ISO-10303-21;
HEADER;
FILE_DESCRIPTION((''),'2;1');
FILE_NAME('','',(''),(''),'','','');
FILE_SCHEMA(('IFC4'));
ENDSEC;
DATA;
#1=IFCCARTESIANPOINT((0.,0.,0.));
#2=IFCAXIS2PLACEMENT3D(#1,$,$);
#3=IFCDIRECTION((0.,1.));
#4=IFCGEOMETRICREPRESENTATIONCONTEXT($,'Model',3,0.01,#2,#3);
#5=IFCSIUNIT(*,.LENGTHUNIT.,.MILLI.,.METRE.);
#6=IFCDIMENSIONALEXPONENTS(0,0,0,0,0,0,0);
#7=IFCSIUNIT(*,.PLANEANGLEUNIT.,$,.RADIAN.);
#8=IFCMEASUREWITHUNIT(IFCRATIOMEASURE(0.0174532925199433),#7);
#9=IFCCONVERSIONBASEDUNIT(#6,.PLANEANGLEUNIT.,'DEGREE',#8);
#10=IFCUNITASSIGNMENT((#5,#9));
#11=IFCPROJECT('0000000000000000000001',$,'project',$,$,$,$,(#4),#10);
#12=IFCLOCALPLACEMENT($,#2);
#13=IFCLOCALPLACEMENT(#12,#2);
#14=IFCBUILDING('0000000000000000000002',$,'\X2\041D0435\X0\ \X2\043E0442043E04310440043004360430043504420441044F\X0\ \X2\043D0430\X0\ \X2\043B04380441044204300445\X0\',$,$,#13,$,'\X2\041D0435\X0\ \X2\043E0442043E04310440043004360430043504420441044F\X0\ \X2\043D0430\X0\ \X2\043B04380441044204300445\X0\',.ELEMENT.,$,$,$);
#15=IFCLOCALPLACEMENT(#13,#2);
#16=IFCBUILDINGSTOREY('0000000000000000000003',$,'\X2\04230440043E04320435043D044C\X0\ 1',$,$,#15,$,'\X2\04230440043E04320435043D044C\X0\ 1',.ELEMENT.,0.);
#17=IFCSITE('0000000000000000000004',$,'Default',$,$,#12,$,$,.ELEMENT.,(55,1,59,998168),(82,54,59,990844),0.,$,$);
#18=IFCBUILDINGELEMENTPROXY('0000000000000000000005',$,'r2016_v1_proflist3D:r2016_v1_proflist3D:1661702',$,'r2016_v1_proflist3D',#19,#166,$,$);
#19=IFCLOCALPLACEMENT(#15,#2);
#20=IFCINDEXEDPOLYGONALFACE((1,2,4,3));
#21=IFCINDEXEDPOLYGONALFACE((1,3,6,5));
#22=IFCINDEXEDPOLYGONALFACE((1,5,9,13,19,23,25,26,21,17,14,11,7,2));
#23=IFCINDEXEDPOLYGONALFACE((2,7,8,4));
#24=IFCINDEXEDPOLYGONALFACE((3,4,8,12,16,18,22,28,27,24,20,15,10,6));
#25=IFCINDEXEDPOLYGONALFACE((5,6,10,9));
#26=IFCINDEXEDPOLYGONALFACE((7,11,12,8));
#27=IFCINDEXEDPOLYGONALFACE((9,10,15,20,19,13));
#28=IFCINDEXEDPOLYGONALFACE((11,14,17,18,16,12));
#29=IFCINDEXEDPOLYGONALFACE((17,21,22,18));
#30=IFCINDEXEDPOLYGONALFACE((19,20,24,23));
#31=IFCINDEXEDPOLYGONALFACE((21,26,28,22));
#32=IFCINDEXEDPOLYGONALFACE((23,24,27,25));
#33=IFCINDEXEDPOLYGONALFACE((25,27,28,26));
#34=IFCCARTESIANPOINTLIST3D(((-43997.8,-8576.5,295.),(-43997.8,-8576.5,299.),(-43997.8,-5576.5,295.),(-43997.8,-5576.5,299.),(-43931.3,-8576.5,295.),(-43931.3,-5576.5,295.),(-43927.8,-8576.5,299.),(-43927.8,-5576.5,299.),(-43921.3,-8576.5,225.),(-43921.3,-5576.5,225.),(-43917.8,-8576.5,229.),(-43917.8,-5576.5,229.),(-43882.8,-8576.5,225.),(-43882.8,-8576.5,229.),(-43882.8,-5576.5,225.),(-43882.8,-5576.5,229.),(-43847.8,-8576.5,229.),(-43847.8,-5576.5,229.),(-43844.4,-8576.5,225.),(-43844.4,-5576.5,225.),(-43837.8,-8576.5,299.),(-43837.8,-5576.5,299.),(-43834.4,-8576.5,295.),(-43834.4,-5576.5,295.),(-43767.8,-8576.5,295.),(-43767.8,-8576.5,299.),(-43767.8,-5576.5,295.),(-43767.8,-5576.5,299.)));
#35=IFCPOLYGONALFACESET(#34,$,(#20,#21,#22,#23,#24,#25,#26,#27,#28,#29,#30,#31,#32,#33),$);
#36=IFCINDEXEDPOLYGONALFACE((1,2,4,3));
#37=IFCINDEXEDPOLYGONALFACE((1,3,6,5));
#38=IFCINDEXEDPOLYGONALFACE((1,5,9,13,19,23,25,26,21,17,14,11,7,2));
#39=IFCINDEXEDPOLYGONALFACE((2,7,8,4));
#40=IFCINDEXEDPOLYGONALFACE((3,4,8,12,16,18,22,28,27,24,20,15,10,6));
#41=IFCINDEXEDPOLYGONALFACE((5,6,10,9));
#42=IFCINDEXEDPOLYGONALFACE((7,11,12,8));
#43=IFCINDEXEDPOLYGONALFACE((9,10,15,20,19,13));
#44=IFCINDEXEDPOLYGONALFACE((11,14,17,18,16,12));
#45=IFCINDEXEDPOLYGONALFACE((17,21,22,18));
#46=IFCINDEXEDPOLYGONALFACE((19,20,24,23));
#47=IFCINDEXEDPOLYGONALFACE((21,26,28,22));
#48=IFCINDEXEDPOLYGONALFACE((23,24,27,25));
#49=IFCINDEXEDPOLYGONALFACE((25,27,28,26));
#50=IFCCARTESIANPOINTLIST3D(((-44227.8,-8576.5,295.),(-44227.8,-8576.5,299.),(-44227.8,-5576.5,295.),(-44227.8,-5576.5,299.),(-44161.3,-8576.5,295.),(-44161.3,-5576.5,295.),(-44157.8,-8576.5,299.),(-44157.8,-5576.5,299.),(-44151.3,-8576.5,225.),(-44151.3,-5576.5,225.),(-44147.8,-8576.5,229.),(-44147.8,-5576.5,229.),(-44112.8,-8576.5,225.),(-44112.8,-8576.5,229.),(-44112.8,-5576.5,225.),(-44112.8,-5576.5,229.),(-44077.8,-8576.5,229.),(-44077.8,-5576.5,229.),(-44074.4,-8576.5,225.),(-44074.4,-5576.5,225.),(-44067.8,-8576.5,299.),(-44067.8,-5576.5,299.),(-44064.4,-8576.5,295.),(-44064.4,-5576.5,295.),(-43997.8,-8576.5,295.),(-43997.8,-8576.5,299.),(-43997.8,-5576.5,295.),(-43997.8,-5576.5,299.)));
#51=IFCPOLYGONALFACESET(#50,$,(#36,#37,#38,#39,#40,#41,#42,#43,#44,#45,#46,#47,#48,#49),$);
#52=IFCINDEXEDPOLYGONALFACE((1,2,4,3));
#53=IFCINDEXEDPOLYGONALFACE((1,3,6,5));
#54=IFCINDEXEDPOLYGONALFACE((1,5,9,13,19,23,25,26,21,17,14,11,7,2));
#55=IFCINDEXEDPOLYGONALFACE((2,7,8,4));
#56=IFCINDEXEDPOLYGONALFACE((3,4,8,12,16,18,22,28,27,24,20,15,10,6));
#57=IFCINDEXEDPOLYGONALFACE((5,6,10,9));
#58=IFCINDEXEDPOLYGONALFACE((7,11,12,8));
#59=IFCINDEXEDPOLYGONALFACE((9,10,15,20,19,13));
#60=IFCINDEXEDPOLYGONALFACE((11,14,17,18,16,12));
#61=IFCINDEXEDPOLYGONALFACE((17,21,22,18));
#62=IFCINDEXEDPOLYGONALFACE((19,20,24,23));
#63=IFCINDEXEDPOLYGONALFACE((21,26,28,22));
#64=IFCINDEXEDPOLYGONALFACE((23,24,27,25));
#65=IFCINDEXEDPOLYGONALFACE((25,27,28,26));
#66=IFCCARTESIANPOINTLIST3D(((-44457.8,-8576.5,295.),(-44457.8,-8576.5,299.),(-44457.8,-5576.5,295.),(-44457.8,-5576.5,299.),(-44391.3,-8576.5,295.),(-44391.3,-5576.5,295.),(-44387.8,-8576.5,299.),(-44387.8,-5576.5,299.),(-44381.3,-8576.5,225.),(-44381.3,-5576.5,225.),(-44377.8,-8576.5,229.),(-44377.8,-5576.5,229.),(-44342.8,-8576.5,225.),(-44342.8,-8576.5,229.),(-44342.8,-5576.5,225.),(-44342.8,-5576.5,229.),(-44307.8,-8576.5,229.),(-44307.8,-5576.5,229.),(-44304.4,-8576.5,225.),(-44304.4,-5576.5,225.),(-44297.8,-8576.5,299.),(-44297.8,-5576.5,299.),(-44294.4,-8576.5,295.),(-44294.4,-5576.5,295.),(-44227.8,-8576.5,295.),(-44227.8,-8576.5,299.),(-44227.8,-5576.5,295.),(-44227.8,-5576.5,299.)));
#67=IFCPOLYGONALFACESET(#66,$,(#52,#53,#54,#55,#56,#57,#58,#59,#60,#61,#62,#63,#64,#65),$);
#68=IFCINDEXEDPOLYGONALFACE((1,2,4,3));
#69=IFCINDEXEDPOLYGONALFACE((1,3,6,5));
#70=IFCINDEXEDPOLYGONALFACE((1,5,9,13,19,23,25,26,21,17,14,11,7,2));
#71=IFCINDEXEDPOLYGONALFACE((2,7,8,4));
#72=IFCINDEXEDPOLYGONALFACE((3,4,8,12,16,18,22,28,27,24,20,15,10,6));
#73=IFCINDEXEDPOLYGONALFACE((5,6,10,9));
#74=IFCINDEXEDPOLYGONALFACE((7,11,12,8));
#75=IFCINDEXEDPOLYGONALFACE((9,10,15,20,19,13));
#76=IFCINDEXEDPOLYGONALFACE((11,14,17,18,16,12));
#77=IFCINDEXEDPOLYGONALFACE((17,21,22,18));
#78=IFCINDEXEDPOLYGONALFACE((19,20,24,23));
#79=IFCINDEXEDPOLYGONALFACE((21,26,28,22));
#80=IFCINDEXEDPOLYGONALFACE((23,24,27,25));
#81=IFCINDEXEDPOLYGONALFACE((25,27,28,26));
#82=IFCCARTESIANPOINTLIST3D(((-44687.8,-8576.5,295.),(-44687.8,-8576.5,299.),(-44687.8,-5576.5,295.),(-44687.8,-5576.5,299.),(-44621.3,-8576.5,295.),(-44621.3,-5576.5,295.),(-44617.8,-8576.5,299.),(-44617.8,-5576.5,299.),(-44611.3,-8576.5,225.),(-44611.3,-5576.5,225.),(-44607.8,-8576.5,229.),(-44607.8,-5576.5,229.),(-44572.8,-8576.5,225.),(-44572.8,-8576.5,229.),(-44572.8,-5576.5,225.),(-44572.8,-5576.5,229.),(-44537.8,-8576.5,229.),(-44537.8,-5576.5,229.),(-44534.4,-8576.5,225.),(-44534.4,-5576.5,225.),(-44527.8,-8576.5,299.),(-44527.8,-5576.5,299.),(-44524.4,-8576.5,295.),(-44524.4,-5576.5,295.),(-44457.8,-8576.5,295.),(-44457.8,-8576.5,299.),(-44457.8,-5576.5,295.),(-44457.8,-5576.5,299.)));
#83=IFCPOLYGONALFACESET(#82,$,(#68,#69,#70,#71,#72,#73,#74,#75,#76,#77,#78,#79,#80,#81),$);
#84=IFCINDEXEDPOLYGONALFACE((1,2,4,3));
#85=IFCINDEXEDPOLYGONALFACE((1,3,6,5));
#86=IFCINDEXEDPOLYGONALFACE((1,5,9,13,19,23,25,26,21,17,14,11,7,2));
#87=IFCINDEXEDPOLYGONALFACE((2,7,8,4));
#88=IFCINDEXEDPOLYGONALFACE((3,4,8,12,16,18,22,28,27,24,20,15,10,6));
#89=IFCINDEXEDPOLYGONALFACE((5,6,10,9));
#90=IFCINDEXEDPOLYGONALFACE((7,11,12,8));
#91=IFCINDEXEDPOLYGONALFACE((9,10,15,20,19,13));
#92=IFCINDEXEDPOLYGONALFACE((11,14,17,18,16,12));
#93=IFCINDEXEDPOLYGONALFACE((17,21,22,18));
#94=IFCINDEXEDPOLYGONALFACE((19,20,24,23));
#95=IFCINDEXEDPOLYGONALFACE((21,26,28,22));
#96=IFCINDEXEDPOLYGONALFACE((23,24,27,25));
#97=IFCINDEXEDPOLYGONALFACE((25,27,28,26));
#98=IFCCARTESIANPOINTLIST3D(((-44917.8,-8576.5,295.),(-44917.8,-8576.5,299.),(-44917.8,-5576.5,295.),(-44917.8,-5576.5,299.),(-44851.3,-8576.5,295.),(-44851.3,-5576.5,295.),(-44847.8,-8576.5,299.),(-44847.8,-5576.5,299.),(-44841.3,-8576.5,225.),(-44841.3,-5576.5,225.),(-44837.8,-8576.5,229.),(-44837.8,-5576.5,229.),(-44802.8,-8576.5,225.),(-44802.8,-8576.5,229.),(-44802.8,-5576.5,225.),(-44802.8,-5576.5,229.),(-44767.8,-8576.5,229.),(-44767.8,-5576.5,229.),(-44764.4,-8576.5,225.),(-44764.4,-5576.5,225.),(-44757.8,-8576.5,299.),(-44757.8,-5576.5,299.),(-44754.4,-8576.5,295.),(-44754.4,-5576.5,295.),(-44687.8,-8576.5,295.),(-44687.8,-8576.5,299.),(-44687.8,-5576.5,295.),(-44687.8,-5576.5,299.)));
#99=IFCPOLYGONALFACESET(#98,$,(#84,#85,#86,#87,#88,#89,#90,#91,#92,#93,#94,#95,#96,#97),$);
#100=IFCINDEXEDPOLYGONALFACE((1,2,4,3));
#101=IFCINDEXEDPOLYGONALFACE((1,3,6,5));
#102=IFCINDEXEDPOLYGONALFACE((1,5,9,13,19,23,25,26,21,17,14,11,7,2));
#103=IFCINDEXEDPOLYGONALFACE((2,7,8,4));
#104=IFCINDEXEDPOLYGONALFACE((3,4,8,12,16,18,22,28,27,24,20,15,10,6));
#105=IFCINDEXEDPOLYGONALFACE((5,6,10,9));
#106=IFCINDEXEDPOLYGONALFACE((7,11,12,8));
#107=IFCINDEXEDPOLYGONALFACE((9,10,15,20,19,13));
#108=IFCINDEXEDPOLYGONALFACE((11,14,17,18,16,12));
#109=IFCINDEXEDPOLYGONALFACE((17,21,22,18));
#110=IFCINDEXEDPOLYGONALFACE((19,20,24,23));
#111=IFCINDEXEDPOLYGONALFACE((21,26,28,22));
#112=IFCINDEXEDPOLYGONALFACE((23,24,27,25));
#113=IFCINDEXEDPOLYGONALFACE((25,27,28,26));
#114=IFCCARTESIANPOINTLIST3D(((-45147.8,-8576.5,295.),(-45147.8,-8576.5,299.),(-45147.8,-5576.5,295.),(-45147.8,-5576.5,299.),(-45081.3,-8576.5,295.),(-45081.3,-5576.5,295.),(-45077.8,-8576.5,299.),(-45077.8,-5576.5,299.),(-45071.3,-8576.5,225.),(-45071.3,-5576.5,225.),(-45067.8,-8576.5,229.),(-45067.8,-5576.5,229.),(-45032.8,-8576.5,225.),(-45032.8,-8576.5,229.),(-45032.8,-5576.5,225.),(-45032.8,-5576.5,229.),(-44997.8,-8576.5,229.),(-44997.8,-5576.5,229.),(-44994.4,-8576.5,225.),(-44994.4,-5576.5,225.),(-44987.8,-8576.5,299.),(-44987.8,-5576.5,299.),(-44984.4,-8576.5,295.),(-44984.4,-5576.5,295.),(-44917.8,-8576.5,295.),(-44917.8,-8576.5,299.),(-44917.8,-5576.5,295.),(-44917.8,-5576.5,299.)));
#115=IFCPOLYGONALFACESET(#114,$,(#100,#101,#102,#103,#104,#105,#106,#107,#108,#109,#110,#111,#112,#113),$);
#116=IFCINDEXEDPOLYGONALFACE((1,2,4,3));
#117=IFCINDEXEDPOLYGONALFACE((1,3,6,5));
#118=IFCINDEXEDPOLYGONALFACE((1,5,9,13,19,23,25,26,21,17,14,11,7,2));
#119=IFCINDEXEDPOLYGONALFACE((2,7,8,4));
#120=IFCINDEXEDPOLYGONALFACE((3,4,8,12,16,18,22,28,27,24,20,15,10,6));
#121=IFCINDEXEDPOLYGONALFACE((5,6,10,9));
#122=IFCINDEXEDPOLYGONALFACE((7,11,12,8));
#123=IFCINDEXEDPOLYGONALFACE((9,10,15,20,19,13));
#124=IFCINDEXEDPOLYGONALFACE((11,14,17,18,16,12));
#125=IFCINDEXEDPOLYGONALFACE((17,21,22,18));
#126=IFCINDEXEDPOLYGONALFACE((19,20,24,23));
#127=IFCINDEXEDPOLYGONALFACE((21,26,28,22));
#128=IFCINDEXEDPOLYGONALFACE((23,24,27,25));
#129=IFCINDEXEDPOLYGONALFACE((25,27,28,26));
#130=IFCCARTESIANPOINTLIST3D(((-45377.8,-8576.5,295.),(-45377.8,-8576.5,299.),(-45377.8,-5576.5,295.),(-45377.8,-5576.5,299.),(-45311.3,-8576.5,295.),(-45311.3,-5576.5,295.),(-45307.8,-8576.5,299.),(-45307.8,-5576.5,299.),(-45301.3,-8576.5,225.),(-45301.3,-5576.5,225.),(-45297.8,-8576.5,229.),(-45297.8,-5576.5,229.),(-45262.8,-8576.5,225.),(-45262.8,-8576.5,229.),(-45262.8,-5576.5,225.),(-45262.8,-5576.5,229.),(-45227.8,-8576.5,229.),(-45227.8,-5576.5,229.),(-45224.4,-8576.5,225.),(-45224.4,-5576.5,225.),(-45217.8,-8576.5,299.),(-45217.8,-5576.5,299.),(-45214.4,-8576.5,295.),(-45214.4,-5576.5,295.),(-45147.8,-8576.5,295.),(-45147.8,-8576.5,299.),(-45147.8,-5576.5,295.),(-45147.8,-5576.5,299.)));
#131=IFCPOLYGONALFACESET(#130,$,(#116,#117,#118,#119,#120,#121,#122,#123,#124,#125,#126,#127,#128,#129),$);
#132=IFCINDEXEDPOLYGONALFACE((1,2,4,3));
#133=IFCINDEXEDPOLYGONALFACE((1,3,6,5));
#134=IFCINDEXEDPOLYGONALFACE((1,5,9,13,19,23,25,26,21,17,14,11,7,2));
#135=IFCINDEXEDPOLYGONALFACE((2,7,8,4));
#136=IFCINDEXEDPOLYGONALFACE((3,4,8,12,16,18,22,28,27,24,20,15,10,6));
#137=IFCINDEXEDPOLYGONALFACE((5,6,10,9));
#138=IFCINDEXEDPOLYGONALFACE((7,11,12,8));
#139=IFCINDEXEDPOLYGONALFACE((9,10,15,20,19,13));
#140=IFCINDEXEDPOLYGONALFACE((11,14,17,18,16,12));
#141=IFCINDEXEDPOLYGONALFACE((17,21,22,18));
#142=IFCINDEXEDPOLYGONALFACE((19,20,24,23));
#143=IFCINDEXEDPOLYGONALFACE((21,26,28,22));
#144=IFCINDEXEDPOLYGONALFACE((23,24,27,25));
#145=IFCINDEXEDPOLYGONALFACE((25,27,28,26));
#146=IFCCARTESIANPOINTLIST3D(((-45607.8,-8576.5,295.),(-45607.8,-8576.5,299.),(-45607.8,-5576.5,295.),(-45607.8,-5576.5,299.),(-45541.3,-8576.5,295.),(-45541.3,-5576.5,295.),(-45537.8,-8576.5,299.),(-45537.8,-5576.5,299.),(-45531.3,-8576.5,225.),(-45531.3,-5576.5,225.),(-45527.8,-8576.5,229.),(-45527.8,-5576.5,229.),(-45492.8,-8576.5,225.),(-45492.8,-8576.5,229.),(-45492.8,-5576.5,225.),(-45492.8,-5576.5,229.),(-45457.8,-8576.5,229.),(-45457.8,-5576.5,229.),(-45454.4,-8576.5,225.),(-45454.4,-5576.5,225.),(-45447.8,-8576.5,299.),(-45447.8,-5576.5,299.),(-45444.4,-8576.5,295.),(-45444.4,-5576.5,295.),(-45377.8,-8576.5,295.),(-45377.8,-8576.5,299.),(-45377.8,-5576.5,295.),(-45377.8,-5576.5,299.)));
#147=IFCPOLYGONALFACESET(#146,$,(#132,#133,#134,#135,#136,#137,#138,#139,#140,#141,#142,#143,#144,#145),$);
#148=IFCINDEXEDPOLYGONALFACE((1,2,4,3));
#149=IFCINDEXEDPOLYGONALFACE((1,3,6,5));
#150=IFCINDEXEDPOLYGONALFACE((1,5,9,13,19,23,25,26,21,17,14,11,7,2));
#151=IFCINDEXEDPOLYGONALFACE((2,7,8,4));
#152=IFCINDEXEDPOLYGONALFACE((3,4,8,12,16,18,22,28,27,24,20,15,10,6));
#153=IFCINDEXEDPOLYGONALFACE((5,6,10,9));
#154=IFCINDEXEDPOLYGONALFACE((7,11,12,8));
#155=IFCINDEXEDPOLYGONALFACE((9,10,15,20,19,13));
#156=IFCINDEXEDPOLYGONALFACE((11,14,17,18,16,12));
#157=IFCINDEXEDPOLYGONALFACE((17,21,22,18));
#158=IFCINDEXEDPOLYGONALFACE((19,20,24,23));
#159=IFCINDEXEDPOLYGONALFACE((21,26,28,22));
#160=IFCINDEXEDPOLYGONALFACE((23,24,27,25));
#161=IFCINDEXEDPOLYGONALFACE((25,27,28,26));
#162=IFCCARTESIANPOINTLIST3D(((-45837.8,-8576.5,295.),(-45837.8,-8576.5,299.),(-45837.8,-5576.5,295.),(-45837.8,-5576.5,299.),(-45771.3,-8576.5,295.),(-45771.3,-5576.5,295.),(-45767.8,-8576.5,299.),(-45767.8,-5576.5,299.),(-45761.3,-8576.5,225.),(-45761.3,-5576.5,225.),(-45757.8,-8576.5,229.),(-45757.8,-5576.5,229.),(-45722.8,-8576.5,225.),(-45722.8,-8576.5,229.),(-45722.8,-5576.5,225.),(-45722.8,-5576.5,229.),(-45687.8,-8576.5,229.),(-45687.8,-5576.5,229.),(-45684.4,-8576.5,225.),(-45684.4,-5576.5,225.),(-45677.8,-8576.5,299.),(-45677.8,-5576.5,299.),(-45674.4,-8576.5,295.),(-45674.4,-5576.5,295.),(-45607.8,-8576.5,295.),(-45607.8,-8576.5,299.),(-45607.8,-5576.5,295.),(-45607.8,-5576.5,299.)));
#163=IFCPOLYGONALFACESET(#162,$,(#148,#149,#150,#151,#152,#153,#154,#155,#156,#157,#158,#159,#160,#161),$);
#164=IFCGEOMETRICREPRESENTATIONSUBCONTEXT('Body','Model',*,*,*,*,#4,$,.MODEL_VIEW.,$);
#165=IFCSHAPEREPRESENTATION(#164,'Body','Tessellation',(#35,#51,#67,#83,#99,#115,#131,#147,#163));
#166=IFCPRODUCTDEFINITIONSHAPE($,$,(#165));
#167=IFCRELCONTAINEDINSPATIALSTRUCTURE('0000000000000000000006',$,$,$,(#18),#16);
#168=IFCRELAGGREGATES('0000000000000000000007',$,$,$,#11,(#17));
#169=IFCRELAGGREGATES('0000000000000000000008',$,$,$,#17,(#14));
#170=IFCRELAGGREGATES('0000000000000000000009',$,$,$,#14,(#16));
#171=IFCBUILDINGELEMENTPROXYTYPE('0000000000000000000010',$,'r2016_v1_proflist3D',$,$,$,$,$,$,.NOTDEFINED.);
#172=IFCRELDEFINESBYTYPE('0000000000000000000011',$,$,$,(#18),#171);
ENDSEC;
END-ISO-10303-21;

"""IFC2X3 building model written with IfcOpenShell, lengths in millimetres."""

from ifc_helpers import new_model, entity, si_unit, converted_unit, direction, frame, origin, place, context, subcontext, project, spatial, polyline, outline, extrude, source, transform, mapped, type_object, type_shapes, element, save


model = new_model("IFC2X3")

# Units and contexts
model_context = context("Model", 3, precision=0.01, world=origin(), true_north=direction((0.0, 1.0)))
body_context = subcontext(model_context, "Body", "Model", "MODEL_VIEW")
ifc_project = project(units=[si_unit("LENGTHUNIT", "METRE", prefix="MILLI"), converted_unit("PLANEANGLEUNIT", "DEGREE", entity("IfcRatioMeasure", 0.0174532925199433), si_unit("PLANEANGLEUNIT", "RADIAN"), dimensions=[0, 0, 0, 0, 0, 0, 0])], contexts=[model_context])

# Site, building, storey
site_placement = place(None, origin())
site = spatial("IfcSite", under=ifc_project, at=site_placement, Name="Default", CompositionType="ELEMENT", RefLatitude=(55, 1, 59, 998168), RefLongitude=(82, 54, 59, 990844), RefElevation=0.0)
building_placement = place(site_placement, origin())
building = spatial("IfcBuilding", under=site, at=building_placement, Name="Не отображается на листах", LongName="Не отображается на листах", CompositionType="ELEMENT")
storey_placement = place(building_placement, frame((0.0, 0.0, 0.0)))
storey = spatial("IfcBuildingStorey", under=building, at=storey_placement, Name="Уровень 1", LongName="Уровень 1", CompositionType="ELEMENT", Elevation=0.0)

# Building element proxy
building_element_proxy_type = type_object("IfcBuildingElementProxyType", Name="r2016_v1_proflist3D", PredefinedType="NOTDEFINED")
shared_shape = source(origin(), body_context, "Body", "SweptSolid", [
    extrude(outline(polyline([(-38.0, -40.0), (-47.9, -109.3), (-44.0, -109.9), (-34.6, -44.0), (36.1, -44.0), (41.6, -5.9), (47.0, 32.1), (-20.9, 51.9), (-11.5, 117.8), (-15.4, 118.4), (-25.3, 49.1), (42.6, 29.3), (37.6, -5.4), (32.7, -40.0), (-38.0, -40.0)])), frame((1955.0, -3000.0, -32.0), z_axis=(0.0, -1.0, 0.0), x_axis=(0.141421, 0.0, -0.989949)), (0.0, 0.0, -1.0), 3000.0),
    extrude(outline(polyline([(-38.0, -40.0), (-47.9, -109.3), (-44.0, -109.9), (-34.6, -44.0), (36.1, -44.0), (41.6, -5.9), (47.0, 32.1), (-20.9, 51.9), (-11.5, 117.8), (-15.4, 118.4), (-25.3, 49.1), (42.6, 29.3), (37.6, -5.4), (32.7, -40.0), (-38.0, -40.0)])), frame((1725.0, -3000.0, -32.0), z_axis=(0.0, -1.0, 0.0), x_axis=(0.141421, 0.0, -0.989949)), (0.0, 0.0, -1.0), 3000.0),
    extrude(outline(polyline([(-38.0, -40.0), (-47.9, -109.3), (-44.0, -109.9), (-34.6, -44.0), (36.1, -44.0), (41.6, -5.9), (47.0, 32.1), (-20.9, 51.9), (-11.5, 117.8), (-15.4, 118.4), (-25.3, 49.1), (42.6, 29.3), (37.6, -5.4), (32.7, -40.0), (-38.0, -40.0)])), frame((1495.0, -3000.0, -32.0), z_axis=(0.0, -1.0, 0.0), x_axis=(0.141421, 0.0, -0.989949)), (0.0, 0.0, -1.0), 3000.0),
    extrude(outline(polyline([(-38.0, -40.0), (-47.9, -109.3), (-44.0, -109.9), (-34.6, -44.0), (36.1, -44.0), (41.6, -5.9), (47.0, 32.1), (-20.9, 51.9), (-11.5, 117.8), (-15.4, 118.4), (-25.3, 49.1), (42.6, 29.3), (37.6, -5.4), (32.7, -40.0), (-38.0, -40.0)])), frame((1265.0, -3000.0, -32.0), z_axis=(0.0, -1.0, 0.0), x_axis=(0.141421, 0.0, -0.989949)), (0.0, 0.0, -1.0), 3000.0),
    extrude(outline(polyline([(-38.0, -40.0), (-47.9, -109.3), (-44.0, -109.9), (-34.6, -44.0), (36.1, -44.0), (41.6, -5.9), (47.0, 32.1), (-20.9, 51.9), (-11.5, 117.8), (-15.4, 118.4), (-25.3, 49.1), (42.6, 29.3), (37.6, -5.4), (32.7, -40.0), (-38.0, -40.0)])), frame((1035.0, -3000.0, -32.0), z_axis=(0.0, -1.0, 0.0), x_axis=(0.141421, 0.0, -0.989949)), (0.0, 0.0, -1.0), 3000.0),
    extrude(outline(polyline([(-38.0, -40.0), (-47.9, -109.3), (-44.0, -109.9), (-34.6, -44.0), (36.1, -44.0), (41.6, -5.9), (47.0, 32.1), (-20.9, 51.9), (-11.5, 117.8), (-15.4, 118.4), (-25.3, 49.1), (42.6, 29.3), (37.6, -5.4), (32.7, -40.0), (-38.0, -40.0)])), frame((805.0, -3000.0, -32.0), z_axis=(0.0, -1.0, 0.0), x_axis=(0.141421, 0.0, -0.989949)), (0.0, 0.0, -1.0), 3000.0),
    extrude(outline(polyline([(-38.0, -40.0), (-47.9, -109.3), (-44.0, -109.9), (-34.6, -44.0), (36.1, -44.0), (41.6, -5.9), (47.0, 32.1), (-20.9, 51.9), (-11.5, 117.8), (-15.4, 118.4), (-25.3, 49.1), (42.6, 29.3), (37.6, -5.4), (32.7, -40.0), (-38.0, -40.0)])), frame((575.0, -3000.0, -32.0), z_axis=(0.0, -1.0, 0.0), x_axis=(0.141421, 0.0, -0.989949)), (0.0, 0.0, -1.0), 3000.0),
    extrude(outline(polyline([(-38.0, -40.0), (-47.9, -109.3), (-44.0, -109.9), (-34.6, -44.0), (36.1, -44.0), (41.6, -5.9), (47.0, 32.1), (-20.9, 51.9), (-11.5, 117.8), (-15.4, 118.4), (-25.3, 49.1), (42.6, 29.3), (37.6, -5.4), (32.7, -40.0), (-38.0, -40.0)])), frame((345.0, -3000.0, -32.0), z_axis=(0.0, -1.0, 0.0), x_axis=(0.141421, 0.0, -0.989949)), (0.0, 0.0, -1.0), 3000.0),
    extrude(outline(polyline([(-38.0, -40.0), (-47.9, -109.3), (-44.0, -109.9), (-34.6, -44.0), (36.1, -44.0), (41.6, -5.9), (47.0, 32.1), (-20.9, 51.9), (-11.5, 117.8), (-15.4, 118.4), (-25.3, 49.1), (42.6, 29.3), (37.6, -5.4), (32.7, -40.0), (-38.0, -40.0)])), frame((115.0, -3000.0, -32.0), z_axis=(0.0, -1.0, 0.0), x_axis=(0.141421, 0.0, -0.989949)), (0.0, 0.0, -1.0), 3000.0),
])
type_shapes(building_element_proxy_type, [shared_shape])
proxy_1_placement = place(storey_placement, frame((-45837.8, -5576.5, 299.0)))
element("IfcBuildingElementProxy", 1, at=proxy_1_placement, inside=storey, type_object=building_element_proxy_type, Name="r2016_v1_proflist3D:r2016_v1_proflist3D:1661702", ObjectType="r2016_v1_proflist3D", context=body_context, shape_type="MappedRepresentation", body=[
    mapped(shared_shape, transform((0.0, 0.0, 0.0), scale=1.0)),
])

save(model, "model.ifc")
